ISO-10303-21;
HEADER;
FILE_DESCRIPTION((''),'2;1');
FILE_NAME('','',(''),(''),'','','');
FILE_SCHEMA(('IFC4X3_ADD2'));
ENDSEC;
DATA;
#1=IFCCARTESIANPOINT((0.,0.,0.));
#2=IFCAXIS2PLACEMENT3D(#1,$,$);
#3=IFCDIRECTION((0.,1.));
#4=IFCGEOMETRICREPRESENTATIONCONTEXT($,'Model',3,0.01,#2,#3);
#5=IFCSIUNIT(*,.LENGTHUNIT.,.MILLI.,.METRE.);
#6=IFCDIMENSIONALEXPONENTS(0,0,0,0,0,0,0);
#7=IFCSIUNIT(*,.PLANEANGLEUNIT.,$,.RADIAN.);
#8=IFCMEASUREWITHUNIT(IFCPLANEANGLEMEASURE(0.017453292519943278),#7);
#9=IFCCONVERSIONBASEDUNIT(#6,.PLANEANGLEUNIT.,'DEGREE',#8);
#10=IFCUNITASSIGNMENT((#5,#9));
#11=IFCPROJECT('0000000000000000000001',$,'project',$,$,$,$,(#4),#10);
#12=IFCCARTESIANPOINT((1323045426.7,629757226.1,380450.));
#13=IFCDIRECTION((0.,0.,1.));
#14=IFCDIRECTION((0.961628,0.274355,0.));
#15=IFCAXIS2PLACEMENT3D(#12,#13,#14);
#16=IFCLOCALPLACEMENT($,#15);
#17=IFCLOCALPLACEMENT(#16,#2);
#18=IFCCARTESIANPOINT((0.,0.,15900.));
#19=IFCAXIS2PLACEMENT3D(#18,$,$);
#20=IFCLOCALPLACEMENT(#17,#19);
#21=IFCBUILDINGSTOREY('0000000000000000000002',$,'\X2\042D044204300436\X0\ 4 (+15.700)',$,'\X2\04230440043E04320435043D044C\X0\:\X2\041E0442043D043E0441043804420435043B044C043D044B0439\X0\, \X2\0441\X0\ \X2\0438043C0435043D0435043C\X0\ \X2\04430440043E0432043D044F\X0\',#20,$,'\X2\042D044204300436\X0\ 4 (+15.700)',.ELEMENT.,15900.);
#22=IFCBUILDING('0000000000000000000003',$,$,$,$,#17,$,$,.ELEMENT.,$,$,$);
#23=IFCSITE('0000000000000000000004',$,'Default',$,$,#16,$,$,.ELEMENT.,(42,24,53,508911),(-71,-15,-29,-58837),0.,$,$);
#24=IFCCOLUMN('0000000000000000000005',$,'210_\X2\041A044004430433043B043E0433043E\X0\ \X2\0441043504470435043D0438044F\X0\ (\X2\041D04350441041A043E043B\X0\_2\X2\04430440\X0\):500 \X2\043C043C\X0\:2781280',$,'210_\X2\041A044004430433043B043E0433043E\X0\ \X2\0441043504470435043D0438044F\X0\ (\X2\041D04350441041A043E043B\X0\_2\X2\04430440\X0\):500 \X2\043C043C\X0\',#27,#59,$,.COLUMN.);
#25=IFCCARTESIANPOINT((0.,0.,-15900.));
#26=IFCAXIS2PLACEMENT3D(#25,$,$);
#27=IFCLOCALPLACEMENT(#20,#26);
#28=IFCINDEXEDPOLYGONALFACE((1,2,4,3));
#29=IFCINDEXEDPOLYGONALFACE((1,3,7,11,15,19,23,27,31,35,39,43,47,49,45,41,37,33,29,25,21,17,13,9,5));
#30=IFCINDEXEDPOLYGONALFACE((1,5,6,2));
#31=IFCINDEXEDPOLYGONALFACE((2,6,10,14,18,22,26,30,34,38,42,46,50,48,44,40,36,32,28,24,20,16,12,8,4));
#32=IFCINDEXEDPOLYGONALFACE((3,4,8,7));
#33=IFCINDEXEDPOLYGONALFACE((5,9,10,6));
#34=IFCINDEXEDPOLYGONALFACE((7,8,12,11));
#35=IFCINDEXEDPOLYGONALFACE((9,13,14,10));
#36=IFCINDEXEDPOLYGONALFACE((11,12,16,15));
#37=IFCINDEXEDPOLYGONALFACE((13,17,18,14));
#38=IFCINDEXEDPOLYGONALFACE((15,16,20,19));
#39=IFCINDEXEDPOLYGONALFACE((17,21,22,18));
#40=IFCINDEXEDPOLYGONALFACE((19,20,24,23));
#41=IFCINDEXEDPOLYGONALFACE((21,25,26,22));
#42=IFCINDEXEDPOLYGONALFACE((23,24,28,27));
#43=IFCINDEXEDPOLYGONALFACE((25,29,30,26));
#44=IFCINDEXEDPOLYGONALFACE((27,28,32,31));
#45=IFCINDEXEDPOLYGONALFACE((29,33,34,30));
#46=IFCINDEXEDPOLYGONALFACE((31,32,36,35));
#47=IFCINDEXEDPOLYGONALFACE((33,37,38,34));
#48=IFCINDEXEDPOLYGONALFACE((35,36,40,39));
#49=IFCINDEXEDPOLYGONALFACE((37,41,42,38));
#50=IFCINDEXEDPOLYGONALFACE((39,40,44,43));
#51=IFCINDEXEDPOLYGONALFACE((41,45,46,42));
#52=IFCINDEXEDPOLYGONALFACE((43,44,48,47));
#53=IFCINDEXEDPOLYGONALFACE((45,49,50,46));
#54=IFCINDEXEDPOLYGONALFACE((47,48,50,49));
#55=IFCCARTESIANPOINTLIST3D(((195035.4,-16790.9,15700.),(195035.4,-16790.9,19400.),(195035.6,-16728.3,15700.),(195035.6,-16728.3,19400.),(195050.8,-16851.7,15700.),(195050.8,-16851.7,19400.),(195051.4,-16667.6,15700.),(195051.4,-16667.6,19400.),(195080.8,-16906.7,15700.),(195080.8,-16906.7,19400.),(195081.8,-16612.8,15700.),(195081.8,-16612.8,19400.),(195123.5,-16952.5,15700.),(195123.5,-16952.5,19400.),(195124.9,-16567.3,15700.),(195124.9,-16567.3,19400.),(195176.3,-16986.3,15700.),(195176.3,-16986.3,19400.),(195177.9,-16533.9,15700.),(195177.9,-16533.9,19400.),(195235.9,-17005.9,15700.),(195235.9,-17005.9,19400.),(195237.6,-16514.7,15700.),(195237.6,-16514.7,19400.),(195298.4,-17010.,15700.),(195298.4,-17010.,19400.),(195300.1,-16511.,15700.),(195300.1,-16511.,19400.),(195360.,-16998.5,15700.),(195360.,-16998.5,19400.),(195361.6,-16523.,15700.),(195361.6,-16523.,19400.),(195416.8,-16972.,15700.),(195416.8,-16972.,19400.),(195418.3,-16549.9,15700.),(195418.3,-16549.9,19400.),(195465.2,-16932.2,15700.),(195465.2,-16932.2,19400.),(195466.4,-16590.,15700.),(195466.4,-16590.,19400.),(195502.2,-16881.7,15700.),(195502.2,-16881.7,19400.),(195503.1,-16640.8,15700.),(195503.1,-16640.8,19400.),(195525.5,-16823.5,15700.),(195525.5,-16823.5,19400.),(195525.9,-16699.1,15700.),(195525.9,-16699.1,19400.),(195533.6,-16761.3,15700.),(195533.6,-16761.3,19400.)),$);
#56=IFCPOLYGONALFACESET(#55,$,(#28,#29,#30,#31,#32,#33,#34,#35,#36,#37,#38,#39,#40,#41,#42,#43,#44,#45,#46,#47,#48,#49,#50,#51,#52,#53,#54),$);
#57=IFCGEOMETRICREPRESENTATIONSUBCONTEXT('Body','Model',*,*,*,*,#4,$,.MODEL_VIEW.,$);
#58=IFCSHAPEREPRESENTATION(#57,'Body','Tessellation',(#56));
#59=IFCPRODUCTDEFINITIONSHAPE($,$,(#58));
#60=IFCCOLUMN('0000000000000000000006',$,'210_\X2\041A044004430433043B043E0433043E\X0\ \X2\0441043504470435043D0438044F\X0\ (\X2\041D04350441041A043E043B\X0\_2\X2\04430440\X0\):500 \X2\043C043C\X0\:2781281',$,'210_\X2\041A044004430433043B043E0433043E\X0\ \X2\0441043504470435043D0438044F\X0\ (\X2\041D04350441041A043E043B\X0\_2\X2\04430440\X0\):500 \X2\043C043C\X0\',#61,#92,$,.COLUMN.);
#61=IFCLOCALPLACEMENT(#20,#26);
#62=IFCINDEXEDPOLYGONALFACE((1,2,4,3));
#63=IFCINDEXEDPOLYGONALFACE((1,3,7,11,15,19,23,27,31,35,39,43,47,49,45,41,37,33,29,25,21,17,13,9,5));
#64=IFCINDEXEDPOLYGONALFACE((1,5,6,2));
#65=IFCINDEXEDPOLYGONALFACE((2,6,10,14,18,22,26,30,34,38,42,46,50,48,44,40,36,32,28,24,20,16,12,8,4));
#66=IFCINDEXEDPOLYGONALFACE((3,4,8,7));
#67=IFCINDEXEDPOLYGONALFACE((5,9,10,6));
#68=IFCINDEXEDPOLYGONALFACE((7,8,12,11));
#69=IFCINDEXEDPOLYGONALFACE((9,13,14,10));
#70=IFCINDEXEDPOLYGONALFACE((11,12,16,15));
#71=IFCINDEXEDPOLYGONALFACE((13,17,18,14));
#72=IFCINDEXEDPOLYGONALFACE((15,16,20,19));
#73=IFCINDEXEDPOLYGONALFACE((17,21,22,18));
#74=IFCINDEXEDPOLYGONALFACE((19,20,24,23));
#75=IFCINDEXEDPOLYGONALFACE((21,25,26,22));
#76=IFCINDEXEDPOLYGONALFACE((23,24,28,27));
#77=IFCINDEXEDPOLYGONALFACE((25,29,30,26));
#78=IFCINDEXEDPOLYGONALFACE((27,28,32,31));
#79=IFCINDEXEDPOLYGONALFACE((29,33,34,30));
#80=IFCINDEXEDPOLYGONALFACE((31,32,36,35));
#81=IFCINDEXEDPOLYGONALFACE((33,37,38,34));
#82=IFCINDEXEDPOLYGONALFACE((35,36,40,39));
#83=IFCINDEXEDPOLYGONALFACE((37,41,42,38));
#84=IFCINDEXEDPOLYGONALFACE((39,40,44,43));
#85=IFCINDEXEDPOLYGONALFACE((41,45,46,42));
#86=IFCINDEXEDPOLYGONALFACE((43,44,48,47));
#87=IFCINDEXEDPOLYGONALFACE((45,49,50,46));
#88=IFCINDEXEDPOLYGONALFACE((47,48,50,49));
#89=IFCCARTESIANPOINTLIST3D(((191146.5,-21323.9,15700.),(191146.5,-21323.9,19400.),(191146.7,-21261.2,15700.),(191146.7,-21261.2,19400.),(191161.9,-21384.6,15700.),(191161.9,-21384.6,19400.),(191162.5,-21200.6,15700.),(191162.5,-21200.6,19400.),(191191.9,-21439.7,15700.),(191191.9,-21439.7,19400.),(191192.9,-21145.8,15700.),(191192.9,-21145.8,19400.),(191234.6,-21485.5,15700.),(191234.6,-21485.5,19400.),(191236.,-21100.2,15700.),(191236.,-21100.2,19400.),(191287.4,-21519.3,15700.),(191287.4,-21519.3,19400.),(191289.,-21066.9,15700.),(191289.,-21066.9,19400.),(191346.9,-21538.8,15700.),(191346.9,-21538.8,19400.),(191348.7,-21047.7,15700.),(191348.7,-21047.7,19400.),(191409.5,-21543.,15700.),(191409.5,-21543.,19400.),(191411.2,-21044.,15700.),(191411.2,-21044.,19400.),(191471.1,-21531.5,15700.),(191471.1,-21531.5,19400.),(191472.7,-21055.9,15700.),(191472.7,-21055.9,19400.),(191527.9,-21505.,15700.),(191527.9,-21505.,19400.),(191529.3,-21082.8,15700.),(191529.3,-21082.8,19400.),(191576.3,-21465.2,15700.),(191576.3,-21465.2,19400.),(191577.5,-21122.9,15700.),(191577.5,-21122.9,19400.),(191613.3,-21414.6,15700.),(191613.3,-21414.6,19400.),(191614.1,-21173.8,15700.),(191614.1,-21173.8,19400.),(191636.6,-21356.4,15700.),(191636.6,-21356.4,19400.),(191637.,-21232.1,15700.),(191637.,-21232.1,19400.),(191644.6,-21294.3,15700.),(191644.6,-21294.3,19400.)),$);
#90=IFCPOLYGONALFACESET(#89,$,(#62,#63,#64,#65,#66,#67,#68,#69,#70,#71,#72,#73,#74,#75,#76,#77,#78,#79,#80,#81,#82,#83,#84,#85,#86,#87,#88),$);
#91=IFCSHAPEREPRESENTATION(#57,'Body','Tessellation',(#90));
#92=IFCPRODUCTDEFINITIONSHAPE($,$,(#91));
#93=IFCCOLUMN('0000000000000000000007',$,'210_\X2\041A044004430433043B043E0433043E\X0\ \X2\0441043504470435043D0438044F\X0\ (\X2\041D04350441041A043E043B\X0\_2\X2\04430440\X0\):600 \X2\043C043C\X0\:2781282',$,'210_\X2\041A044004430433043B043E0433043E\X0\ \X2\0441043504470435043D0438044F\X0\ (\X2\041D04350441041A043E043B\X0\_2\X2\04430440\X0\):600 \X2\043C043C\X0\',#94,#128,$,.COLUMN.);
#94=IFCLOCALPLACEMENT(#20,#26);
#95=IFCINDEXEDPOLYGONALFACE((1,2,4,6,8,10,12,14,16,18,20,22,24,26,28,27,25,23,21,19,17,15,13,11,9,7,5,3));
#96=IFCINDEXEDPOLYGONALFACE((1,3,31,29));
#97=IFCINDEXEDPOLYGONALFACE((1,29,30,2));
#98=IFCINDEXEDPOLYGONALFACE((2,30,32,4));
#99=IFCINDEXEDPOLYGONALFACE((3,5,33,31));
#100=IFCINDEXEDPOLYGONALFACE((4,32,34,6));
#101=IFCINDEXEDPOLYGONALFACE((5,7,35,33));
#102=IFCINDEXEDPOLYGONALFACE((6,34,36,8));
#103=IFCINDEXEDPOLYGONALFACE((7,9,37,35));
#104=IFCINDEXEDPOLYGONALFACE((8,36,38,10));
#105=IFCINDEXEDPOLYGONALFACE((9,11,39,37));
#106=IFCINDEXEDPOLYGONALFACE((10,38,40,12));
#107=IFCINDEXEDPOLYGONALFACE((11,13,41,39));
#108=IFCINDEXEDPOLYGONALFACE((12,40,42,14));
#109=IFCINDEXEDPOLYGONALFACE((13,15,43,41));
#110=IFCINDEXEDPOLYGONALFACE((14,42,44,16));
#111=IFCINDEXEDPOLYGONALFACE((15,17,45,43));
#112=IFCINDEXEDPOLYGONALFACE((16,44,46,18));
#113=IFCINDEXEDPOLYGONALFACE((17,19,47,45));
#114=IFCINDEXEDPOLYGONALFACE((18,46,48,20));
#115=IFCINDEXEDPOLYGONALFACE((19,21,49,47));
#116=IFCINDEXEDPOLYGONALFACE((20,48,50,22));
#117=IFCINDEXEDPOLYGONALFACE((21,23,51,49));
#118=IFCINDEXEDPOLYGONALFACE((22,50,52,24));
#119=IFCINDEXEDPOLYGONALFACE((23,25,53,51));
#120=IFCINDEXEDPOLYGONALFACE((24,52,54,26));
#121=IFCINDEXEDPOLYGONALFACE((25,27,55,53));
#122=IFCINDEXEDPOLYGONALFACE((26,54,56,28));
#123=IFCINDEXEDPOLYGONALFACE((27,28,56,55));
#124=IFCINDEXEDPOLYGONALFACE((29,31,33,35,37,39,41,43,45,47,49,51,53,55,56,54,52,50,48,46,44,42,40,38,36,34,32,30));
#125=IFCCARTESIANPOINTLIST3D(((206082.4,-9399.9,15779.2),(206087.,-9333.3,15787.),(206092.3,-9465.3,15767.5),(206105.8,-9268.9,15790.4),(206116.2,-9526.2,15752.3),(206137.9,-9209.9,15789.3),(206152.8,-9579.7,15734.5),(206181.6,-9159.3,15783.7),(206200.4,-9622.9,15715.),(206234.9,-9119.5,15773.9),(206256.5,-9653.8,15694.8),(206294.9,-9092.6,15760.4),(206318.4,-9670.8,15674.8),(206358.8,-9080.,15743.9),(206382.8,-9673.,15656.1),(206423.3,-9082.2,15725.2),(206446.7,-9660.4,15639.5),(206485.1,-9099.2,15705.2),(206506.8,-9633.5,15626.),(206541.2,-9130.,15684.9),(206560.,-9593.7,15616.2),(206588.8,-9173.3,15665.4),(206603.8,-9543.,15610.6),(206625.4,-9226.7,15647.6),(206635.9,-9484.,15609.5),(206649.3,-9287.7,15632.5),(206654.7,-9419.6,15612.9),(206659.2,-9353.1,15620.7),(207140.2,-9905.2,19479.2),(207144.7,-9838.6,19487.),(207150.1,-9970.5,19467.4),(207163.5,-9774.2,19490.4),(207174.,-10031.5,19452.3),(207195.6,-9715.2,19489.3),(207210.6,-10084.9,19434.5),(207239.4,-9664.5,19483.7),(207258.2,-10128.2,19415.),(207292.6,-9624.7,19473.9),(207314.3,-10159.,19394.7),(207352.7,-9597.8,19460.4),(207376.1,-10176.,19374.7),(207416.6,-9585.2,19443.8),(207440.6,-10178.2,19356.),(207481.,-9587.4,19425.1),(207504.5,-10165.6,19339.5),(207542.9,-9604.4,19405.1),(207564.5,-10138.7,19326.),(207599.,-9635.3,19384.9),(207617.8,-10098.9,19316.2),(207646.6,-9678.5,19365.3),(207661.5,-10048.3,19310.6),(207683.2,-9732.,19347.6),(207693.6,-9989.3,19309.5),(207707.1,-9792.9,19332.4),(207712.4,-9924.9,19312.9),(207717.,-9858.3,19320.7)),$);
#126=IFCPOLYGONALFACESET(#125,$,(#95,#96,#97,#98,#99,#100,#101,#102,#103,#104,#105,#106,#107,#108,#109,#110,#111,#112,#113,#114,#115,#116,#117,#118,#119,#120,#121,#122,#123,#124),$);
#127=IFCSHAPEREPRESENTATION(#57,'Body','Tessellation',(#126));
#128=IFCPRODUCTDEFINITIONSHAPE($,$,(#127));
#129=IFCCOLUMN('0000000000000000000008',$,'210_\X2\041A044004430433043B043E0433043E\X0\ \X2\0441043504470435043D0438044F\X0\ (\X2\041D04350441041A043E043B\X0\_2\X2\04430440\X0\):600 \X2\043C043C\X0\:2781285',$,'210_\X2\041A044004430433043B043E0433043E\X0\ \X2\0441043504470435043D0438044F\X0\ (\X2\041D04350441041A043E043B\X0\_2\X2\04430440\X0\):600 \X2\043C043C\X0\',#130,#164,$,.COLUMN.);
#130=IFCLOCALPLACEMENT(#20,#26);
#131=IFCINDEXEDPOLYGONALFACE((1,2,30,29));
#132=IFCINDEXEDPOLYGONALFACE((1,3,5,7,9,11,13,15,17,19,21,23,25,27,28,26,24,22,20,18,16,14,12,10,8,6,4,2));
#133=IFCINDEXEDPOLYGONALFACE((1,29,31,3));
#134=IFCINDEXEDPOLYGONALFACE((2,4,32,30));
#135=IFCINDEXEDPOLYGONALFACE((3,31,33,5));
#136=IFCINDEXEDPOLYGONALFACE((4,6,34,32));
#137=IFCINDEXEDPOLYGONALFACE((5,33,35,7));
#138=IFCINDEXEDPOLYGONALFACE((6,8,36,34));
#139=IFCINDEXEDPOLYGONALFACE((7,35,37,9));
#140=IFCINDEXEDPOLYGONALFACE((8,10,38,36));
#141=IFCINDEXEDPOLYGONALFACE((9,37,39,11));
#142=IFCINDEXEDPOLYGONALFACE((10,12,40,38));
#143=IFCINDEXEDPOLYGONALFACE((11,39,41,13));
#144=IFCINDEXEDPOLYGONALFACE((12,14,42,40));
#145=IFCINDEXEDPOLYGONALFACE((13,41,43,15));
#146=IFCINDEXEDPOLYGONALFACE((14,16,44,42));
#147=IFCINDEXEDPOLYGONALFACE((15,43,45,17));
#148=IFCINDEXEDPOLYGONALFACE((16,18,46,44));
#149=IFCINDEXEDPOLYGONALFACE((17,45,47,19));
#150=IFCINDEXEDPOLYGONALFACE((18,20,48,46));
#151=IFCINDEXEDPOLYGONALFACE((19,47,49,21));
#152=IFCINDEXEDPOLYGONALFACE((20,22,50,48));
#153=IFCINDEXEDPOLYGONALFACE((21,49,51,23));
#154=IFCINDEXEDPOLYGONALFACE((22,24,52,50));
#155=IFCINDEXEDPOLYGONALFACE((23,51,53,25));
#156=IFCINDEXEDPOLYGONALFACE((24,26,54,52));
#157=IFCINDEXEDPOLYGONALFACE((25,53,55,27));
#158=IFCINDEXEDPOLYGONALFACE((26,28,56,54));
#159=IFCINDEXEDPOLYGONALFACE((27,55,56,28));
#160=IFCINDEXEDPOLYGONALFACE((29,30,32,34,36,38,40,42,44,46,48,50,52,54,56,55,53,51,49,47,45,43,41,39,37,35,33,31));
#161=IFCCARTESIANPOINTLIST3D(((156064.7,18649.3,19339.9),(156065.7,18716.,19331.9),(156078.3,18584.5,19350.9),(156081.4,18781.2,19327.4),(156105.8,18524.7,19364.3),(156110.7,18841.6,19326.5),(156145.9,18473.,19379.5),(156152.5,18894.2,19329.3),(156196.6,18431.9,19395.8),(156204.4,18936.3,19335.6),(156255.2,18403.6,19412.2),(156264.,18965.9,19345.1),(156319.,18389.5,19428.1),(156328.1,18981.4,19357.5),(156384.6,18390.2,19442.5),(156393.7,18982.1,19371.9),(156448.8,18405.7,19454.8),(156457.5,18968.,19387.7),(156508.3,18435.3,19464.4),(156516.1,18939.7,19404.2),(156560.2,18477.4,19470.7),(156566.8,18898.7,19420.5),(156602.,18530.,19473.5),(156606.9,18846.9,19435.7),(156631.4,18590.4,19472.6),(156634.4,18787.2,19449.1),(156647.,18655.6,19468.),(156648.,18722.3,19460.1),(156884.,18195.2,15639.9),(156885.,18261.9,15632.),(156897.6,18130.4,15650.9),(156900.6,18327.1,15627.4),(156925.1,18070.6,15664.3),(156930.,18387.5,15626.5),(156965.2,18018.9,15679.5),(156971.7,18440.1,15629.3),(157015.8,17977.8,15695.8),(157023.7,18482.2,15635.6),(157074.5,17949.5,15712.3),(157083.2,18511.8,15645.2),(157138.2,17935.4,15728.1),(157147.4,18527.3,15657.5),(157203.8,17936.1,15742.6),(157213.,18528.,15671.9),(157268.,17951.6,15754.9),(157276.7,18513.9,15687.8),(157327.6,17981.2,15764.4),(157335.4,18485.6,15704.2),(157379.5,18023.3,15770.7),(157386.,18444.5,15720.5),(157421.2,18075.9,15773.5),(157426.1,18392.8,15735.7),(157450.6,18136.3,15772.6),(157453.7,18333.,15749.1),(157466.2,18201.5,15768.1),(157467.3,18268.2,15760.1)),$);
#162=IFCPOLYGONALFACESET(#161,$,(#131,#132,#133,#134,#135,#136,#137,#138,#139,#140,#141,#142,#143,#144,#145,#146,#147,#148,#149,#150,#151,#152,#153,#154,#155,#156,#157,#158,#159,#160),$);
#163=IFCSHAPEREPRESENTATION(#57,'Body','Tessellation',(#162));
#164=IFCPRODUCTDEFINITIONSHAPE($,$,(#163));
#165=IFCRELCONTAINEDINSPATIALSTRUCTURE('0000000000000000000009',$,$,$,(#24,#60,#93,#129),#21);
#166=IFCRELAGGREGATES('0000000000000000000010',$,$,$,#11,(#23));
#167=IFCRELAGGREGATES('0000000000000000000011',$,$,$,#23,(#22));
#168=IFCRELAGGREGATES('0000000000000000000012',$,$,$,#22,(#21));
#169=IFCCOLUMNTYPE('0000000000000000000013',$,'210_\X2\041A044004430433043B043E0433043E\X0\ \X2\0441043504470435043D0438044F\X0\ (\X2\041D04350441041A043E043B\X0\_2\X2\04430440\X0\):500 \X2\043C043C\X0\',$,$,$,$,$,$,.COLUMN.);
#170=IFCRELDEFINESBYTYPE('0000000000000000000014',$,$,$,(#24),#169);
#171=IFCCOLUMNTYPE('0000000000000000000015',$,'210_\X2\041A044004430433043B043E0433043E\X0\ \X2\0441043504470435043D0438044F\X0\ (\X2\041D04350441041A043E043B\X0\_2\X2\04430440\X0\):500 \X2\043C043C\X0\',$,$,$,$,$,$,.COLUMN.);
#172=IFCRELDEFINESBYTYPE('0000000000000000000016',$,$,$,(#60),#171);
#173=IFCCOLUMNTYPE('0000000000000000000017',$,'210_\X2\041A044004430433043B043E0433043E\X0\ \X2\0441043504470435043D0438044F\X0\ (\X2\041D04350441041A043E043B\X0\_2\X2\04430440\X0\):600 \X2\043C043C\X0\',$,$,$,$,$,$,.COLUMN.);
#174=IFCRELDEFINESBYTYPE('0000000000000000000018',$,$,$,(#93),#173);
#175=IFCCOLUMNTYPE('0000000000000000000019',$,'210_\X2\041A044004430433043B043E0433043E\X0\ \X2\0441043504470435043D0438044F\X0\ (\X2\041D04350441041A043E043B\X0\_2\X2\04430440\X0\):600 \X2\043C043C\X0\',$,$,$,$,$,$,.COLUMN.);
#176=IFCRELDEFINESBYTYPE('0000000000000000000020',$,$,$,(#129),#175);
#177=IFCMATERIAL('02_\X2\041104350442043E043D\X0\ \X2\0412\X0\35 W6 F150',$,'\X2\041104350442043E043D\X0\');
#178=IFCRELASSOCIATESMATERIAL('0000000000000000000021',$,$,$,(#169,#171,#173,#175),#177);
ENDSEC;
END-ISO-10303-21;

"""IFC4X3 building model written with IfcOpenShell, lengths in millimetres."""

from ifc_helpers import new_model, entity, si_unit, converted_unit, direction, frame, frame_2d, origin, origin_2d_with_axis, place, context, subcontext, project, spatial, circle, extrude, source, transform, mapped, material, material_profile, profile_set, type_object, type_shapes, element, save


model = new_model("IFC4X3")

# Units and contexts
model_context = context("Model", 3, precision=0.01, world=origin(), true_north=direction((0.0, 1.0)))
body_context = subcontext(model_context, "Body", "Model", "MODEL_VIEW")
ifc_project = project(units=[si_unit("LENGTHUNIT", "METRE", prefix="MILLI"), converted_unit("PLANEANGLEUNIT", "DEGREE", entity("IfcPlaneAngleMeasure", 0.017453292519943278), si_unit("PLANEANGLEUNIT", "RADIAN"), dimensions=[0, 0, 0, 0, 0, 0, 0])], contexts=[model_context])

# Site, building, storey
site_placement = place(None, frame((1323045426.7, 629757226.1, 380450.0), z_axis=(0.0, 0.0, 1.0), x_axis=(0.961628, 0.274355, 0.0)))
site = spatial("IfcSite", under=ifc_project, at=site_placement, Name="Default", CompositionType="ELEMENT", RefLatitude=(42, 24, 53, 508911), RefLongitude=(-71, -15, -29, -58837), RefElevation=0.0)
building_placement = place(site_placement, origin())
building = spatial("IfcBuilding", under=site, at=building_placement, CompositionType="ELEMENT")
storey_placement = place(building_placement, frame((0.0, 0.0, 15900.0)))
storey = spatial("IfcBuildingStorey", under=building, at=storey_placement, Name="Этаж 4 (+15.700)", ObjectType="Уровень:Относительный, с именем уровня", LongName="Этаж 4 (+15.700)", CompositionType="ELEMENT", Elevation=15900.0)

# Columns
ifc_material = material(Name="02_Бетон В35 W6 F150", Category="Бетон")
ifc_material_profile_1 = material_profile(ifc_material, circle(Radius=300.0, at=frame_2d((0.0, 0.0), x_axis=(1.0, 0.0))), Name="600 мм")
ifc_profile_set_1 = profile_set([ifc_material_profile_1], Name="600 мм")
ifc_material_profile_2 = material_profile(ifc_material, circle(Radius=250.0, at=origin_2d_with_axis()), Name="500 мм")
ifc_profile_set_2 = profile_set([ifc_material_profile_2], Name="500 мм")
column_type_1 = type_object("IfcColumnType", Name="210_Круглого сечения (НесКол_2ур):500 мм", PredefinedType="COLUMN", material=ifc_profile_set_2)
shared_shape_1 = source(origin(), body_context, "Body", "SweptSolid", [
    extrude(circle(Radius=250.0, at=origin_2d_with_axis()), frame((195283.6, -16760.5, 15700.0), z_axis=(0.0, 0.0, 1.0), x_axis=(0.87462, -0.48481, 0.0)), (0.0, 0.0, 1.0), 3700.0),
])
type_shapes(column_type_1, [shared_shape_1])
column_1_placement = place(storey_placement, frame((0.0, 0.0, -15900.0)))
element("IfcColumn", 1, at=column_1_placement, inside=storey, type_object=column_type_1, Name="210_Круглого сечения (НесКол_2ур):500 мм:2781280", ObjectType="210_Круглого сечения (НесКол_2ур):500 мм", PredefinedType="COLUMN", context=body_context, shape_type="MappedRepresentation", body=[
    mapped(shared_shape_1, transform((0.0, 0.0, 0.0), scale=1.0)),
])
column_type_2 = type_object("IfcColumnType", Name="210_Круглого сечения (НесКол_2ур):500 мм", PredefinedType="COLUMN", material=ifc_profile_set_2)
shared_shape_2 = source(origin(), body_context, "Body", "SweptSolid", [
    extrude(circle(Radius=250.0, at=origin_2d_with_axis()), frame((191394.6, -21293.4, 15700.0), z_axis=(0.0, 0.0, 1.0), x_axis=(0.87462, -0.48481, 0.0)), (0.0, 0.0, 1.0), 3700.0),
])
type_shapes(column_type_2, [shared_shape_2])
column_2_placement = place(storey_placement, frame((0.0, 0.0, -15900.0)))
element("IfcColumn", 2, at=column_2_placement, inside=storey, type_object=column_type_2, Name="210_Круглого сечения (НесКол_2ур):500 мм:2781281", ObjectType="210_Круглого сечения (НесКол_2ур):500 мм", PredefinedType="COLUMN", context=body_context, shape_type="MappedRepresentation", body=[
    mapped(shared_shape_2, transform((0.0, 0.0, 0.0), scale=1.0)),
])
column_type_3 = type_object("IfcColumnType", Name="210_Круглого сечения (НесКол_2ур):600 мм", PredefinedType="COLUMN", material=ifc_profile_set_1)
shared_shape_3 = source(origin(), body_context, "Body", "SweptSolid", [
    extrude(circle(Radius=300.0, at=frame_2d((0.0, 0.0), x_axis=(1.0, 0.0))), frame((206370.8, -9376.5, 15700.0), z_axis=(0.272531, -0.130178, 0.9533), x_axis=(0.040062, -0.98841, -0.146425)), (0.0, 0.0, 1.0), 3881.2),
])
type_shapes(column_type_3, [shared_shape_3])
column_3_placement = place(storey_placement, frame((0.0, 0.0, -15900.0)))
element("IfcColumn", 3, at=column_3_placement, inside=storey, type_object=column_type_3, Name="210_Круглого сечения (НесКол_2ур):600 мм:2781282", ObjectType="210_Круглого сечения (НесКол_2ур):600 мм", PredefinedType="COLUMN", context=body_context, shape_type="MappedRepresentation", body=[
    mapped(shared_shape_3, transform((0.0, 0.0, 0.0), scale=1.0)),
])
column_type_4 = type_object("IfcColumnType", Name="210_Круглого сечения (НесКол_2ур):600 мм", PredefinedType="COLUMN", material=ifc_profile_set_1)
shared_shape_4 = source(origin(), body_context, "Body", "SweptSolid", [
    extrude(circle(Radius=300.0, at=frame_2d((0.0, 0.0), x_axis=(1.0, 0.0))), frame((157175.6, 18231.7, 15700.0), z_axis=(-0.214651, 0.118983, 0.969416), x_axis=(-0.83508, -0.537108, -0.118983)), (0.0, 0.0, 1.0), 3816.7),
])
type_shapes(column_type_4, [shared_shape_4])
column_4_placement = place(storey_placement, frame((0.0, 0.0, -15900.0)))
element("IfcColumn", 4, at=column_4_placement, inside=storey, type_object=column_type_4, Name="210_Круглого сечения (НесКол_2ур):600 мм:2781285", ObjectType="210_Круглого сечения (НесКол_2ур):600 мм", PredefinedType="COLUMN", context=body_context, shape_type="MappedRepresentation", body=[
    mapped(shared_shape_4, transform((0.0, 0.0, 0.0), scale=1.0)),
])

save(model, "model.ifc")
